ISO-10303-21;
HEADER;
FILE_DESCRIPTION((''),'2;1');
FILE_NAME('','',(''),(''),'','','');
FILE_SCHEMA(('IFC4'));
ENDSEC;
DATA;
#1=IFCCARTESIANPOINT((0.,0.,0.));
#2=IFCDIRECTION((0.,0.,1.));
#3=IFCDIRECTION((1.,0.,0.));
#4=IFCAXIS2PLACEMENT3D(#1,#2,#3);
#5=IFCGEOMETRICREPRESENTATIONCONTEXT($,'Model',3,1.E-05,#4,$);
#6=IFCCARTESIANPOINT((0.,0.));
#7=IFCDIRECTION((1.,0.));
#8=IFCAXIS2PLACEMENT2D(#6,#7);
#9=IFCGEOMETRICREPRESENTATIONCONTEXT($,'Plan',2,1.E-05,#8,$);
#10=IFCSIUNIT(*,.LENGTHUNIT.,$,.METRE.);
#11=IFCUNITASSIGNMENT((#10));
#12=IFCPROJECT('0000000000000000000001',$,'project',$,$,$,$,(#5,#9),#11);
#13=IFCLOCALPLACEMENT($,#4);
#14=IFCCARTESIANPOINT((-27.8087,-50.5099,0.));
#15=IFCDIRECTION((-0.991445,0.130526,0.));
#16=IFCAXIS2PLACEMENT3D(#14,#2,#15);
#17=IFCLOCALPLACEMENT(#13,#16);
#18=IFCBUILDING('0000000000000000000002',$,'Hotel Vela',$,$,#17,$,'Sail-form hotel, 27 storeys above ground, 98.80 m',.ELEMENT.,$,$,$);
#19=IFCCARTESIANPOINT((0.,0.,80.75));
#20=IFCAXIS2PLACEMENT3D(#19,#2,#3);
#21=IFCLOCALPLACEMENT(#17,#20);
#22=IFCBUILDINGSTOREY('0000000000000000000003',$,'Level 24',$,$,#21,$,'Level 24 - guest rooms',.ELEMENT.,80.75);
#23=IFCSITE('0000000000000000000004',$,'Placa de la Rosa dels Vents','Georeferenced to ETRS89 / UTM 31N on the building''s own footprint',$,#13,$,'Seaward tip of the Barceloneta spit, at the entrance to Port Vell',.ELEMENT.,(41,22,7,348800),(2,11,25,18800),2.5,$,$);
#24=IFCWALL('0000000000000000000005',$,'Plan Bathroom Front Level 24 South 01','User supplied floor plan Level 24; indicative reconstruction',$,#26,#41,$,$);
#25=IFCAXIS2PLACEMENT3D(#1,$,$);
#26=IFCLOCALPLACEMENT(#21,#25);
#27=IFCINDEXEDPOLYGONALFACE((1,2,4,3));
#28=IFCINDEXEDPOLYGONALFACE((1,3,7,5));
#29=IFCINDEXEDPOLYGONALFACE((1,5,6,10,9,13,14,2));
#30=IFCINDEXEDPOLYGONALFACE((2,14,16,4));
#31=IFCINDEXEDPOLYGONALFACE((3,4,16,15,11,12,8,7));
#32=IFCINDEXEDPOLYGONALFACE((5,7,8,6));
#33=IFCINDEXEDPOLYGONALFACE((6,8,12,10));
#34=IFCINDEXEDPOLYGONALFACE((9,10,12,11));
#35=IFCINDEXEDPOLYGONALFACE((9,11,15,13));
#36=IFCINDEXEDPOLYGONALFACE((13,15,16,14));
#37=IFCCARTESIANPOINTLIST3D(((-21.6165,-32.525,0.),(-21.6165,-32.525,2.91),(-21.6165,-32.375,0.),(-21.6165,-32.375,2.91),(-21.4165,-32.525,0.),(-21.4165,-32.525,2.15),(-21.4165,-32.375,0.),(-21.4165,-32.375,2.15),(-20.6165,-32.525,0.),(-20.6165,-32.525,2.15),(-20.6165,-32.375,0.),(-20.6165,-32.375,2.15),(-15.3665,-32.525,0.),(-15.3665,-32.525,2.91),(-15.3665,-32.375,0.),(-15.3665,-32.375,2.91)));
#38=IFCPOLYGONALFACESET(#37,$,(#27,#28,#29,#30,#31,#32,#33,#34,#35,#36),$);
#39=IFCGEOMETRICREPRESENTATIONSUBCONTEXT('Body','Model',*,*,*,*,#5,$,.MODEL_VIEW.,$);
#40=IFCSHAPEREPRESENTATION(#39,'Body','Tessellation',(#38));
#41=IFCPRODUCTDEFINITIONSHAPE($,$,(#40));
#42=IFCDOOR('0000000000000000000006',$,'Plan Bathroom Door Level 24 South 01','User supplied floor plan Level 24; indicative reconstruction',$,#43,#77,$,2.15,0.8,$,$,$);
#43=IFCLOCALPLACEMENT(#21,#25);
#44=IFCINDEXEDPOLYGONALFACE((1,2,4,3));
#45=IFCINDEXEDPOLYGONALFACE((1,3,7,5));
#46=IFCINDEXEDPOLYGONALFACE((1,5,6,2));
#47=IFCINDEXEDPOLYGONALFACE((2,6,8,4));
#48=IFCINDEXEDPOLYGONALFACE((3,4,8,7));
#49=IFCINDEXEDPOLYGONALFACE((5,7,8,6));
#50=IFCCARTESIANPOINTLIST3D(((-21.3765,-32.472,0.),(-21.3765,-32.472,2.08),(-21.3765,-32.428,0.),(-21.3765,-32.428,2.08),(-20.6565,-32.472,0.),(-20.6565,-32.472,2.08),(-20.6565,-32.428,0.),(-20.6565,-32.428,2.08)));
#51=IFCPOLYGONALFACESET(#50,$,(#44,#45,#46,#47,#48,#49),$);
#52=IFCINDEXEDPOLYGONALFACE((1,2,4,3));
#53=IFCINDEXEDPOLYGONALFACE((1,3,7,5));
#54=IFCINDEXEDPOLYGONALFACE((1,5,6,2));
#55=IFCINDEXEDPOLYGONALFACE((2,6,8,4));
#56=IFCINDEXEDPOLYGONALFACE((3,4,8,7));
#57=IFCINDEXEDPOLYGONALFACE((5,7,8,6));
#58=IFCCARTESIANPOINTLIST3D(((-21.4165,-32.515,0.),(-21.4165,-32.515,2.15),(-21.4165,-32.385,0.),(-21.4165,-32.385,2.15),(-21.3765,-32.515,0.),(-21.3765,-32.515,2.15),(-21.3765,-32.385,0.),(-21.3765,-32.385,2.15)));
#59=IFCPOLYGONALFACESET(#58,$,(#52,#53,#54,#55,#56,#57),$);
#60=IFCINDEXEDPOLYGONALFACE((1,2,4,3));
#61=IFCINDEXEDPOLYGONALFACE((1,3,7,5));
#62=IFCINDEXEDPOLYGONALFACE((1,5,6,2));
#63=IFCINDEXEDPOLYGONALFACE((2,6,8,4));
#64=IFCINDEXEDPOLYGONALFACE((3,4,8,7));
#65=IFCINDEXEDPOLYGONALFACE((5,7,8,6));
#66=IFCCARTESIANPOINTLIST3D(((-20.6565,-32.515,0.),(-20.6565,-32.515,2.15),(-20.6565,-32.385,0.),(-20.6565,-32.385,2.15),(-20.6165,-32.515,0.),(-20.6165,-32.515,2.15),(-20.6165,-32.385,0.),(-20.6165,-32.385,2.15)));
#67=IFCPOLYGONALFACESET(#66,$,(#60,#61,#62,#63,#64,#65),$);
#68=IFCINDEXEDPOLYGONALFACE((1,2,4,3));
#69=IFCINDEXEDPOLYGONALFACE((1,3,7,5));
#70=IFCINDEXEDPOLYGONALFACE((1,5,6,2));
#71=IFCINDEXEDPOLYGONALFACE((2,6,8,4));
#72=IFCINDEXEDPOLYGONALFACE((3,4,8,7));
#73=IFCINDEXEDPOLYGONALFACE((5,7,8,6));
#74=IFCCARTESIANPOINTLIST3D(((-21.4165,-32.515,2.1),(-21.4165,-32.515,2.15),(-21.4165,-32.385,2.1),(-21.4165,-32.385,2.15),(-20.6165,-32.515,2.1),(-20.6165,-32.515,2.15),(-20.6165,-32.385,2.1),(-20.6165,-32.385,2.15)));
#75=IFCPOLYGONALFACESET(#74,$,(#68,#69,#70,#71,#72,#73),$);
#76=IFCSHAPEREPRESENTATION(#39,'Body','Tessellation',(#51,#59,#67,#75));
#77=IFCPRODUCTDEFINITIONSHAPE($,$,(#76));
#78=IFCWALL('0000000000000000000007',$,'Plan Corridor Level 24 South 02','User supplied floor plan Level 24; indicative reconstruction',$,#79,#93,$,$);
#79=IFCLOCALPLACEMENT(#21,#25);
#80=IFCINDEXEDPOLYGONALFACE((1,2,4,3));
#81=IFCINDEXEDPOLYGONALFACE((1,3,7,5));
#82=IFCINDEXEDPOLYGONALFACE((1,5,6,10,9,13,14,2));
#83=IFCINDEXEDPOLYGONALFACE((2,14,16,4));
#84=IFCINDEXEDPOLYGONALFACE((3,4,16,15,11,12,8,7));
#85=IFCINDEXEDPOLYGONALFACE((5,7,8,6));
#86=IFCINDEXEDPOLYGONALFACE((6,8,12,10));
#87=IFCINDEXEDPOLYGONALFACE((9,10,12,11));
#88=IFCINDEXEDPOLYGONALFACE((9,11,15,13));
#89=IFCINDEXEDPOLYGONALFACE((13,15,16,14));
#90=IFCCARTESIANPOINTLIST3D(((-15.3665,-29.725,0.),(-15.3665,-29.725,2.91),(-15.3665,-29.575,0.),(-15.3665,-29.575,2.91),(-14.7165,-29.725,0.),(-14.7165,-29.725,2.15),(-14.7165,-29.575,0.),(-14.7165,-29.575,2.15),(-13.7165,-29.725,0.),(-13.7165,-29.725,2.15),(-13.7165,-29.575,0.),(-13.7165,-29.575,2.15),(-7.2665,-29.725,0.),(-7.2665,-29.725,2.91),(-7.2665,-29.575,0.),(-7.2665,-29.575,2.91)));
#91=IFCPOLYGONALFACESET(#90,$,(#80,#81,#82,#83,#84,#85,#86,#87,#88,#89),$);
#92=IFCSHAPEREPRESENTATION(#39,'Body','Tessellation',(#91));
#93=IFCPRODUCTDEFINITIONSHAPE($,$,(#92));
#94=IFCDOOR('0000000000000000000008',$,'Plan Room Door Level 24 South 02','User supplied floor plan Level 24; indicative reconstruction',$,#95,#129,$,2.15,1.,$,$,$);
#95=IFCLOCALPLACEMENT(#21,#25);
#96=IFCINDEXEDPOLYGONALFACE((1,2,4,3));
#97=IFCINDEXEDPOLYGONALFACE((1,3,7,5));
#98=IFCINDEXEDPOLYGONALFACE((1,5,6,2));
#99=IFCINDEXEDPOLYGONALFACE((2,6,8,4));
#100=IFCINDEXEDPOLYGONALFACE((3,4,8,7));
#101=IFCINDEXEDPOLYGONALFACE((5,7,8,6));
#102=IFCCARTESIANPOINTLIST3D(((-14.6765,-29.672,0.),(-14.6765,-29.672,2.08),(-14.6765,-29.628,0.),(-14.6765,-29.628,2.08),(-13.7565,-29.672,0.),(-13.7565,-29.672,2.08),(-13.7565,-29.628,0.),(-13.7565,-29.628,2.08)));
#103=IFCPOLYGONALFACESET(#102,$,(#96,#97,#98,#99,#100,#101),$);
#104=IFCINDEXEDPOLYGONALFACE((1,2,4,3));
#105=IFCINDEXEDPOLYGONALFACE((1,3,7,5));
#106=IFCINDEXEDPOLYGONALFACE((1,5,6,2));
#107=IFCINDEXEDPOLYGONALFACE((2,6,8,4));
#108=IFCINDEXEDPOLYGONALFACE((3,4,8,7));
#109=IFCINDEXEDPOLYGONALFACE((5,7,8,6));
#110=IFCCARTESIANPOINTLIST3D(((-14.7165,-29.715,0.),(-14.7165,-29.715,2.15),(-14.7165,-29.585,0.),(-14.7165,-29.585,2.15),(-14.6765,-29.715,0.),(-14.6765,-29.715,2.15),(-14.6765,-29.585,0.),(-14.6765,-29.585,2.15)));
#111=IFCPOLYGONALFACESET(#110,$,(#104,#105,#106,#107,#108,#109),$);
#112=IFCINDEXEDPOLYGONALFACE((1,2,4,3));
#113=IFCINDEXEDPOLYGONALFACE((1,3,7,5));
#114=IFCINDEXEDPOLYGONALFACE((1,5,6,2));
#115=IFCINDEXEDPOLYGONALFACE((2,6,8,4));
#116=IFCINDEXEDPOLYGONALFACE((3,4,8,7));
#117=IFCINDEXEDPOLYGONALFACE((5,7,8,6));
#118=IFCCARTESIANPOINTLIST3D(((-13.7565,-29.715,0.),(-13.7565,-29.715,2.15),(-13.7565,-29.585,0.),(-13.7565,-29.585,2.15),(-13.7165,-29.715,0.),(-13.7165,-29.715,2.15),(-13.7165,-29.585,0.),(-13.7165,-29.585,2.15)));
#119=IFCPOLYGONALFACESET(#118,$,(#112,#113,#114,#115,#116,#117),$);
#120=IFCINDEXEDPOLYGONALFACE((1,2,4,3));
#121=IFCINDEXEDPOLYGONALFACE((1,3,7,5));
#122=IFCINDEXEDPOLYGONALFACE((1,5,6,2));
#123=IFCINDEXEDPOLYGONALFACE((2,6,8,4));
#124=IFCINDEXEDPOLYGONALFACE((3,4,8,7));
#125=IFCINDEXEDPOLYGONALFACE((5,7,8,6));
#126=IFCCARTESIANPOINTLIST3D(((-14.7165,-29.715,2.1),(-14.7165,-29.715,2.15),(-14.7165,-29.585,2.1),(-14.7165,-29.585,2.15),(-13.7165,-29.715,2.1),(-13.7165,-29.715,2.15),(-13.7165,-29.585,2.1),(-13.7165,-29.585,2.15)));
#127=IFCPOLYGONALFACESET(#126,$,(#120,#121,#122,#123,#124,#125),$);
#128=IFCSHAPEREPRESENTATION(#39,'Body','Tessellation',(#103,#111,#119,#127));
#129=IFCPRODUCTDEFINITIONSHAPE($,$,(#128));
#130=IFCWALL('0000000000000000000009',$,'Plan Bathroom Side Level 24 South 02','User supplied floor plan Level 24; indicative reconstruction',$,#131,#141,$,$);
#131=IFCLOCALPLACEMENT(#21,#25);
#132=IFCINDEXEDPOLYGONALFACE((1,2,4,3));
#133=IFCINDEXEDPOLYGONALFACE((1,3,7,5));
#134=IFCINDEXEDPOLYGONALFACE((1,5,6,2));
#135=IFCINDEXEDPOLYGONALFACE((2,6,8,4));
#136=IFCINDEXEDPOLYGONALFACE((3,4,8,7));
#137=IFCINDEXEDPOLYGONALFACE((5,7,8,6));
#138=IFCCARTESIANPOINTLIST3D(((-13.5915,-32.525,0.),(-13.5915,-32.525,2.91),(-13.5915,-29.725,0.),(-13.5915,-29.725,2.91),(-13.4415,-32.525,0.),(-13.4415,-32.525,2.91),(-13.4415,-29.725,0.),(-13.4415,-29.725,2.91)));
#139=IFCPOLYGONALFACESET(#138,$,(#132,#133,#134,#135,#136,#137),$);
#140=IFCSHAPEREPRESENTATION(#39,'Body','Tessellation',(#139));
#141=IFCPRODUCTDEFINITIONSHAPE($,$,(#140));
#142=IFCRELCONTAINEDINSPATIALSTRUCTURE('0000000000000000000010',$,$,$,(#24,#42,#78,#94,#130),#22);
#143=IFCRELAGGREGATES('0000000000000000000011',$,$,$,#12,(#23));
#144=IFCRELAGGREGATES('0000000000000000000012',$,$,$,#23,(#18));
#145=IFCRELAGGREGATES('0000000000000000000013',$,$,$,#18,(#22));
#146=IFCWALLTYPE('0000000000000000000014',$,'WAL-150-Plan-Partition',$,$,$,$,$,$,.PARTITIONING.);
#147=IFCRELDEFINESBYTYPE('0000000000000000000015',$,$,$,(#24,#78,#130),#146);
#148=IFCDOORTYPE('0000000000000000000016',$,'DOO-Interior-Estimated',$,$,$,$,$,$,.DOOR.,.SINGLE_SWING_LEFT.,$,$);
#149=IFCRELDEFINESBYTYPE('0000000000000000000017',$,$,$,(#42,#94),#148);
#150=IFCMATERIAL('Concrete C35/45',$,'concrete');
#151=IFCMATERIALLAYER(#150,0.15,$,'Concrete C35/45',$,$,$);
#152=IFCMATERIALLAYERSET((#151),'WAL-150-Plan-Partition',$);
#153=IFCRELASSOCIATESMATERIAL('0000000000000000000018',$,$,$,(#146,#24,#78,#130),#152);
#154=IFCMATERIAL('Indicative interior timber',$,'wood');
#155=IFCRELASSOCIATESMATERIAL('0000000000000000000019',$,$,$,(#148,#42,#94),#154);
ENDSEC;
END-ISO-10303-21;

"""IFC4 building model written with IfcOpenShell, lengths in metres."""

from ifc_helpers import new_model, si_unit, frame, origin_with_axes, origin_2d_with_axis, place, context, subcontext, project, spatial, line, indexed_curve, outline, extrude, material, layer, layer_set, layer_usage, type_object, element, fill, save


model = new_model("IFC4")

# Units and contexts
model_context = context("Model", 3, precision=1e-05, world=origin_with_axes())
plan_context = context("Plan", 2, precision=1e-05, world=origin_2d_with_axis())
body_context = subcontext(model_context, "Body", "Model", "MODEL_VIEW")
ifc_project = project(units=[si_unit("LENGTHUNIT", "METRE")], contexts=[model_context, plan_context])

# Site, building, storey
site_placement = place(None, origin_with_axes())
site = spatial("IfcSite", under=ifc_project, at=site_placement, Name="Placa de la Rosa dels Vents", Description="Georeferenced to ETRS89 / UTM 31N on the building's own footprint", LongName="Seaward tip of the Barceloneta spit, at the entrance to Port Vell", CompositionType="ELEMENT", RefLatitude=(41, 22, 7, 348800), RefLongitude=(2, 11, 25, 18800), RefElevation=2.5)
building_placement = place(site_placement, frame((-27.8087, -50.5099, 0.0), z_axis=(0.0, 0.0, 1.0), x_axis=(-0.991445, 0.130526, 0.0)))
building = spatial("IfcBuilding", under=site, at=building_placement, Name="Hotel Vela", LongName="Sail-form hotel, 27 storeys above ground, 98.80 m", CompositionType="ELEMENT")
storey_placement = place(building_placement, frame((0.0, 0.0, 80.75), z_axis=(0.0, 0.0, 1.0), x_axis=(1.0, 0.0, 0.0)))
storey = spatial("IfcBuildingStorey", under=building, at=storey_placement, Name="Level 24", LongName="Level 24 - guest rooms", CompositionType="ELEMENT", Elevation=80.75)

# Shared definitions
ifc_material_1 = material(Name="Concrete C35/45", Category="concrete")

# Shared definitions
ifc_layer_1 = layer(ifc_material_1, 0.15, Name="Concrete C35/45")
ifc_layer_set_1 = layer_set([ifc_layer_1], Name="WAL-150-Plan-Partition")
wall_type = type_object("IfcWallType", Name="WAL-150-Plan-Partition", PredefinedType="PARTITIONING", material=ifc_layer_set_1)
ifc_material_2 = material(Name="Indicative interior timber", Category="wood")
door_type = type_object("IfcDoorType", Name="DOO-Interior-Estimated", OperationType="SINGLE_SWING_LEFT", PredefinedType="DOOR", material=ifc_material_2)

# Walls, openings, doors
ifc_layer_usage_1 = layer_usage(ifc_layer_set_1, "AXIS2", "POSITIVE", 0.0)
wall_1_placement = place(storey_placement, frame((-21.6165, -32.525, 0.0), z_axis=(0.0, 0.0, 1.0), x_axis=(1.0, 0.0, 0.0)))
wall_1 = element("IfcWall", 1, at=wall_1_placement, inside=storey, type_object=wall_type, material=ifc_layer_usage_1, Name="Plan Bathroom Front Level 24 South 01", Description="User supplied floor plan Level 24; indicative reconstruction", context=body_context, shape_type="SweptSolid", body=[
    extrude(outline(indexed_curve([(0.0, 0.0), (6.25, 0.0), (6.25, 0.15), (0.0, 0.15)], segments=[line(1, 2, 3, 4, 1)])), origin_with_axes(), (0.0, 0.0, 1.0), 2.91),
])
opening_1_placement = place(wall_1_placement, frame((0.2, -0.085, 0.0), z_axis=(0.0, 0.0, 1.0), x_axis=(1.0, 0.0, 0.0)))
opening_1 = element("IfcOpeningElement", 2, at=opening_1_placement, cuts=wall_1, PredefinedType="OPENING", context=body_context, shape_type="SweptSolid", body=[
    extrude(outline(indexed_curve([(0.0, 0.0), (0.8, 0.0), (0.8, 0.32), (0.0, 0.32)], segments=[line(1, 2, 3, 4, 1)])), origin_with_axes(), (0.0, 0.0, 1.0), 2.15),
])
door_1_placement = place(storey_placement, frame((0.0, 0.0, -80.75), z_axis=(0.0, 0.0, 1.0), x_axis=(1.0, 0.0, 0.0)))
door_1 = element("IfcDoor", 3, at=door_1_placement, inside=storey, type_object=door_type, material=ifc_material_2, Name="Plan Bathroom Door Level 24 South 01", Description="User supplied floor plan Level 24; indicative reconstruction", OverallHeight=2.15, OverallWidth=0.8, context=body_context, shape_type="SweptSolid", body=[
    extrude(outline(indexed_curve([(0.0, 0.0), (0.72, 0.0), (0.72, 0.044), (0.0, 0.044)], segments=[line(1, 2, 3, 4, 1)])), frame((-21.3765, -32.472, 80.75), z_axis=(0.0, 0.0, 1.0), x_axis=(1.0, 0.0, 0.0)), (0.0, 0.0, 1.0), 2.08),
    extrude(outline(indexed_curve([(0.0, 0.0), (0.04, 0.0), (0.04, 0.13), (0.0, 0.13)], segments=[line(1, 2, 3, 4, 1)])), frame((-21.4165, -32.515, 80.75), z_axis=(0.0, 0.0, 1.0), x_axis=(1.0, 0.0, 0.0)), (0.0, 0.0, 1.0), 2.15),
    extrude(outline(indexed_curve([(0.0, 0.0), (0.04, 0.0), (0.04, 0.13), (0.0, 0.13)], segments=[line(1, 2, 3, 4, 1)])), frame((-20.6565, -32.515, 80.75), z_axis=(0.0, 0.0, 1.0), x_axis=(1.0, 0.0, 0.0)), (0.0, 0.0, 1.0), 2.15),
    extrude(outline(indexed_curve([(0.0, 0.0), (0.8, 0.0), (0.8, 0.13), (0.0, 0.13)], segments=[line(1, 2, 3, 4, 1)])), frame((-21.4165, -32.515, 82.85), z_axis=(0.0, 0.0, 1.0), x_axis=(1.0, 0.0, 0.0)), (0.0, 0.0, 1.0), 0.05),
])
fill(opening_1, door_1)
ifc_layer_usage_2 = layer_usage(ifc_layer_set_1, "AXIS2", "POSITIVE", 0.0)
wall_2_placement = place(storey_placement, frame((-15.3665, -29.725, 0.0), z_axis=(0.0, 0.0, 1.0), x_axis=(1.0, 0.0, 0.0)))
wall_2 = element("IfcWall", 4, at=wall_2_placement, inside=storey, type_object=wall_type, material=ifc_layer_usage_2, Name="Plan Corridor Level 24 South 02", Description="User supplied floor plan Level 24; indicative reconstruction", context=body_context, shape_type="SweptSolid", body=[
    extrude(outline(indexed_curve([(0.0, 0.0), (8.1, 0.0), (8.1, 0.15), (0.0, 0.15)], segments=[line(1, 2, 3, 4, 1)])), origin_with_axes(), (0.0, 0.0, 1.0), 2.91),
])
opening_2_placement = place(wall_2_placement, frame((0.65, -0.085, 0.0), z_axis=(0.0, 0.0, 1.0), x_axis=(1.0, 0.0, 0.0)))
opening_2 = element("IfcOpeningElement", 5, at=opening_2_placement, cuts=wall_2, PredefinedType="OPENING", context=body_context, shape_type="SweptSolid", body=[
    extrude(outline(indexed_curve([(0.0, 0.0), (1.0, 0.0), (1.0, 0.32), (0.0, 0.32)], segments=[line(1, 2, 3, 4, 1)])), origin_with_axes(), (0.0, 0.0, 1.0), 2.15),
])
door_2_placement = place(storey_placement, frame((0.0, 0.0, -80.75), z_axis=(0.0, 0.0, 1.0), x_axis=(1.0, 0.0, 0.0)))
door_2 = element("IfcDoor", 6, at=door_2_placement, inside=storey, type_object=door_type, material=ifc_material_2, Name="Plan Room Door Level 24 South 02", Description="User supplied floor plan Level 24; indicative reconstruction", OverallHeight=2.15, OverallWidth=1.0, context=body_context, shape_type="SweptSolid", body=[
    extrude(outline(indexed_curve([(0.0, 0.0), (0.92, 0.0), (0.92, 0.044), (0.0, 0.044)], segments=[line(1, 2, 3, 4, 1)])), frame((-14.6765, -29.672, 80.75), z_axis=(0.0, 0.0, 1.0), x_axis=(1.0, 0.0, 0.0)), (0.0, 0.0, 1.0), 2.08),
    extrude(outline(indexed_curve([(0.0, 0.0), (0.04, 0.0), (0.04, 0.13), (0.0, 0.13)], segments=[line(1, 2, 3, 4, 1)])), frame((-14.7165, -29.715, 80.75), z_axis=(0.0, 0.0, 1.0), x_axis=(1.0, 0.0, 0.0)), (0.0, 0.0, 1.0), 2.15),
    extrude(outline(indexed_curve([(0.0, 0.0), (0.04, 0.0), (0.04, 0.13), (0.0, 0.13)], segments=[line(1, 2, 3, 4, 1)])), frame((-13.7565, -29.715, 80.75), z_axis=(0.0, 0.0, 1.0), x_axis=(1.0, 0.0, 0.0)), (0.0, 0.0, 1.0), 2.15),
    extrude(outline(indexed_curve([(0.0, 0.0), (1.0, 0.0), (1.0, 0.13), (0.0, 0.13)], segments=[line(1, 2, 3, 4, 1)])), frame((-14.7165, -29.715, 82.85), z_axis=(0.0, 0.0, 1.0), x_axis=(1.0, 0.0, 0.0)), (0.0, 0.0, 1.0), 0.05),
])
fill(opening_2, door_2)

# Wall
ifc_layer_usage_3 = layer_usage(ifc_layer_set_1, "AXIS2", "POSITIVE", 0.0)
wall_3_placement = place(storey_placement, frame((-13.5915, -32.525, 0.0), z_axis=(0.0, 0.0, 1.0), x_axis=(1.0, 0.0, 0.0)))
element("IfcWall", 7, at=wall_3_placement, inside=storey, type_object=wall_type, material=ifc_layer_usage_3, Name="Plan Bathroom Side Level 24 South 02", Description="User supplied floor plan Level 24; indicative reconstruction", context=body_context, shape_type="SweptSolid", body=[
    extrude(outline(indexed_curve([(0.0, 0.0), (0.15, 0.0), (0.15, 2.8), (0.0, 2.8)], segments=[line(1, 2, 3, 4, 1)])), origin_with_axes(), (0.0, 0.0, 1.0), 2.91),
])

save(model, "model.ifc")
